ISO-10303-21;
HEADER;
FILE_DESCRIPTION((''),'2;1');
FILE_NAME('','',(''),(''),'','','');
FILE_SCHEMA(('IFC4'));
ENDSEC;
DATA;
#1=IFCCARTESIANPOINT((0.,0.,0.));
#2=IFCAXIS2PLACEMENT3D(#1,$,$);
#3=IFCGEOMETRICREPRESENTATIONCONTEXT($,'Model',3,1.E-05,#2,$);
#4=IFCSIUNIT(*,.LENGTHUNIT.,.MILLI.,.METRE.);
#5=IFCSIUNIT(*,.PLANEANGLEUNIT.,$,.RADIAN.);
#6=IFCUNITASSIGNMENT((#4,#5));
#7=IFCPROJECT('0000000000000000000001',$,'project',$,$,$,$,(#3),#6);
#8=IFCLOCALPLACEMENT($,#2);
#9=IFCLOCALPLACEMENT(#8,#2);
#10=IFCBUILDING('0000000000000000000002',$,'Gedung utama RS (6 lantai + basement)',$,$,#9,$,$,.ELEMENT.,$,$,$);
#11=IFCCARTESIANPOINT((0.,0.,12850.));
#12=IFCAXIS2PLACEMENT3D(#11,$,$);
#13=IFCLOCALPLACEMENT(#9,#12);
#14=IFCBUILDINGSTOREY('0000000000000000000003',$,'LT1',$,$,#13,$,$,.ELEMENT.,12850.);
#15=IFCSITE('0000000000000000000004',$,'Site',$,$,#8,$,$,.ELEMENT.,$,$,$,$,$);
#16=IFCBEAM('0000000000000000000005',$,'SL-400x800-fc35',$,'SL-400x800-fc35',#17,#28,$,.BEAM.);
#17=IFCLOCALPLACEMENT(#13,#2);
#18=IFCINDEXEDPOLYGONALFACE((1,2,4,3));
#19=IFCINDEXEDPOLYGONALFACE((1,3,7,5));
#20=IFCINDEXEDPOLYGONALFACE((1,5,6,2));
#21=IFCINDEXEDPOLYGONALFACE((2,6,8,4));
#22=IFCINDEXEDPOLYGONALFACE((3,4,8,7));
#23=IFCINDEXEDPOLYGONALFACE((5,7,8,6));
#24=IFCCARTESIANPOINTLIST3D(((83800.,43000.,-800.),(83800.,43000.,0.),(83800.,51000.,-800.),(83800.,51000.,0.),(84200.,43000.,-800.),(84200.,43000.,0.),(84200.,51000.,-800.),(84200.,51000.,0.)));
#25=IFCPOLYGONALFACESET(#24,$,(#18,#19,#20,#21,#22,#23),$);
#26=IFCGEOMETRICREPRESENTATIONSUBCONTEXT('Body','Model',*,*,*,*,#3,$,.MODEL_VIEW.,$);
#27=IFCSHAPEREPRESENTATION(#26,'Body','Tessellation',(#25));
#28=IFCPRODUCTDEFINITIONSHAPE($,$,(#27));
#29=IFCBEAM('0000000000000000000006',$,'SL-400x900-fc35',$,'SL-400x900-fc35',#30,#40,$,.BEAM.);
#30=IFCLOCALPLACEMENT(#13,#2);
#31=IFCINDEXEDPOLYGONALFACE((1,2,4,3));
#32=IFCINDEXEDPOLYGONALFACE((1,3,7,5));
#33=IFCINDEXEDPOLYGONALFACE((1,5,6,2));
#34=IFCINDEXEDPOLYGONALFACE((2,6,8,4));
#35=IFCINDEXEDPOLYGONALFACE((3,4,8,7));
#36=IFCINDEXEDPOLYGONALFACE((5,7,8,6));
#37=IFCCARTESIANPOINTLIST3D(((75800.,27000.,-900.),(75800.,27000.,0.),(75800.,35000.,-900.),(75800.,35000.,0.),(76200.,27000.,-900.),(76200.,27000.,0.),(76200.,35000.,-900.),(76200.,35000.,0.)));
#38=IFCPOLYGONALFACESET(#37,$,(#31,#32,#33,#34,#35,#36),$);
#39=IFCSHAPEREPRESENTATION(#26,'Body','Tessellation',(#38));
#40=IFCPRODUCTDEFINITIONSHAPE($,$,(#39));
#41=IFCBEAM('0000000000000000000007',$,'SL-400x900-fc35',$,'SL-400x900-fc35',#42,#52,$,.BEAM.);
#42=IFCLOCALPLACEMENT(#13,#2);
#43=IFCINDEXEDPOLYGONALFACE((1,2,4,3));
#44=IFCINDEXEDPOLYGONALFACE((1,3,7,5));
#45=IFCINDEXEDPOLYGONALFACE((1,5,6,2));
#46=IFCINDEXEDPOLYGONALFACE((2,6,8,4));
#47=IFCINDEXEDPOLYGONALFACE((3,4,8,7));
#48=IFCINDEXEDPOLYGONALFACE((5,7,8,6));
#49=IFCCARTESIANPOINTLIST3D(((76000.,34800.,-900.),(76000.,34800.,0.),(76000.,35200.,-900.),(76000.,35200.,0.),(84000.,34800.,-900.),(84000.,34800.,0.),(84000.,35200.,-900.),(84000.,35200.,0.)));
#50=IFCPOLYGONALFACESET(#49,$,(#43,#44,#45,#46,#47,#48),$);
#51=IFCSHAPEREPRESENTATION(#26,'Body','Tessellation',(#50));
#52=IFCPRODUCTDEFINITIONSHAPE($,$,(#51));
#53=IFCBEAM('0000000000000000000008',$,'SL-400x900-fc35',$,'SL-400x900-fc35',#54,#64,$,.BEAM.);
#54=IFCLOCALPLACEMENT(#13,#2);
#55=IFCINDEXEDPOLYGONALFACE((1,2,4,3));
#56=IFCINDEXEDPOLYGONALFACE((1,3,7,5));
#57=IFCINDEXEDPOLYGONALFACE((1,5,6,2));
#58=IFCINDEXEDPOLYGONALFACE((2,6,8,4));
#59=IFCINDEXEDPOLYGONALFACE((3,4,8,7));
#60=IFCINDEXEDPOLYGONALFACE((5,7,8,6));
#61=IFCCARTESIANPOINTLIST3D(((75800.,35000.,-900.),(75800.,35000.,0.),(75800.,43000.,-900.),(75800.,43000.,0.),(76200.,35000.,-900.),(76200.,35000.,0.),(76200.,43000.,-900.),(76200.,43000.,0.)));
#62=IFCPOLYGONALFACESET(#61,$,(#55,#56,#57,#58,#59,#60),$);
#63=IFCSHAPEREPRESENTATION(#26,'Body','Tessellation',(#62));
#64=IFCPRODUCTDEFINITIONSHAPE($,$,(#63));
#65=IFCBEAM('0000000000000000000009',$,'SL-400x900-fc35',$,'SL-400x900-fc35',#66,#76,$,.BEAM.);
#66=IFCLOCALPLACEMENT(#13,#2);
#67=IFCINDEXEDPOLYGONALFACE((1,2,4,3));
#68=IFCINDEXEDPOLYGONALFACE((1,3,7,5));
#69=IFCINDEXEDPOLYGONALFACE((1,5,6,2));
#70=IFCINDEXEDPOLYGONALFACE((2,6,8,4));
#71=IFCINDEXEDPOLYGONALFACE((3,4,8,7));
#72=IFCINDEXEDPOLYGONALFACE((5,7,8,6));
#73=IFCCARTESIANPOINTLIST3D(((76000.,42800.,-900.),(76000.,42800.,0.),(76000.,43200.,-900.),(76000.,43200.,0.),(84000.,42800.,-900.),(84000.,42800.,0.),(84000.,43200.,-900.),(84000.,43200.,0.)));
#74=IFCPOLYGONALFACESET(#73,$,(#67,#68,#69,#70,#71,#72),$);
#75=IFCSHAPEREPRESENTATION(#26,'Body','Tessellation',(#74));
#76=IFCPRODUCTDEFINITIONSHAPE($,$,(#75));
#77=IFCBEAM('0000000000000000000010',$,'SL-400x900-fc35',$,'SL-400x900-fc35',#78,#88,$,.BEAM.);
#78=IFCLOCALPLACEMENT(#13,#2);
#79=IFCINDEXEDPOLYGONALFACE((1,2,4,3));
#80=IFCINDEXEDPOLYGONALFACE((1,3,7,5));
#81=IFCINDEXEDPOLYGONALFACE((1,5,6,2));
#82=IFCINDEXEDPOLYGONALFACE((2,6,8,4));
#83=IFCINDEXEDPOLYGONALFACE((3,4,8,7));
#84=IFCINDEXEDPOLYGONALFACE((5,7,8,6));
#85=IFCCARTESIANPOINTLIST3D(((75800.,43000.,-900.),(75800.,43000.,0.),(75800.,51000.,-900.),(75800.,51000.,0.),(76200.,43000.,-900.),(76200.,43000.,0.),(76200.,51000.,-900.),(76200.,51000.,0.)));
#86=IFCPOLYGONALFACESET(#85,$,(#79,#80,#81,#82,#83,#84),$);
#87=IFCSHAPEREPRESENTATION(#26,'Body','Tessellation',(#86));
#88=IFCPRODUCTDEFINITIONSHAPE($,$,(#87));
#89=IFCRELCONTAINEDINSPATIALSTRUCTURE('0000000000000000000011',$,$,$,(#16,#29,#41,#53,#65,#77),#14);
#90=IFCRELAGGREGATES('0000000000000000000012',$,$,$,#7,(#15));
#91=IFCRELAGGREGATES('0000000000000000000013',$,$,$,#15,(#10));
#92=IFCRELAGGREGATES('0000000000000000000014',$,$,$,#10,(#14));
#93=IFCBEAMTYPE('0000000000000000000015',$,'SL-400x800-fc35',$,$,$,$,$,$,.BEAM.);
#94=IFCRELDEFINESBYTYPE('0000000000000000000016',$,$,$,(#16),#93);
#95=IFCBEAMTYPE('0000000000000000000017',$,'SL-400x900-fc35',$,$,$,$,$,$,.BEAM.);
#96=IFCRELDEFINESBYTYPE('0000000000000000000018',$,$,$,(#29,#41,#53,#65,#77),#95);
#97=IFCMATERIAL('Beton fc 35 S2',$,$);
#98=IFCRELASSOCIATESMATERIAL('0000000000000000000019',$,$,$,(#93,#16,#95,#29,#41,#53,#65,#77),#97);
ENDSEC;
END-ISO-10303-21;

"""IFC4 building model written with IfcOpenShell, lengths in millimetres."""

from ifc_helpers import new_model, si_unit, frame, origin, origin_2d, place, context, subcontext, project, spatial, rectangle, extrude, material, material_profile, profile_set, profile_usage, type_object, element, save


model = new_model("IFC4")

# Units and contexts
model_context = context("Model", 3, precision=1e-05, world=origin())
body_context = subcontext(model_context, "Body", "Model", "MODEL_VIEW")
ifc_project = project(units=[si_unit("LENGTHUNIT", "METRE", prefix="MILLI"), si_unit("PLANEANGLEUNIT", "RADIAN")], contexts=[model_context])

# Site, building, storey
site_placement = place(None, origin())
site = spatial("IfcSite", under=ifc_project, at=site_placement, Name="Site", CompositionType="ELEMENT")
building_placement = place(site_placement, origin())
building = spatial("IfcBuilding", under=site, at=building_placement, Name="Gedung utama RS (6 lantai + basement)", CompositionType="ELEMENT")
storey_placement = place(building_placement, frame((0.0, 0.0, 12850.0)))
storey = spatial("IfcBuildingStorey", under=building, at=storey_placement, Name="LT1", CompositionType="ELEMENT", Elevation=12850.0)

# Beams
ifc_material = material(Name="Beton fc 35 S2")
ifc_material_profile_1 = material_profile(ifc_material, rectangle(XDim=400.0, YDim=800.0, at=origin_2d()), Name="SL-400x800-fc35")
ifc_profile_set_1 = profile_set([ifc_material_profile_1], Name="SL-400x800-fc35")
ifc_profile_usage_1 = profile_usage(ifc_profile_set_1, cardinal=8)
beam_type_1 = type_object("IfcBeamType", Name="SL-400x800-fc35", PredefinedType="BEAM", material=ifc_profile_set_1)
for number, where, name in (
    (1, (84000.0, 43000.0, -400.0), "SL-400x800-fc35"),
):
    element("IfcBeam", number, at=place(storey_placement, frame(where)), inside=storey, type_object=beam_type_1, material=ifc_profile_usage_1, Name=name, ObjectType="SL-400x800-fc35", PredefinedType="BEAM", context=body_context, shape_type="SweptSolid", body=[
        extrude(rectangle(XDim=400.0, YDim=800.0, at=origin_2d()), frame((0.0, 0.0, 0.0), z_axis=(0.0, 1.0, 0.0), x_axis=(-1.0, 0.0, 0.0)), (0.0, 0.0, 1.0), 8000.0),
    ])
ifc_material_profile_2 = material_profile(ifc_material, rectangle(XDim=400.0, YDim=900.0, at=origin_2d()), Name="SL-400x900-fc35")
ifc_profile_set_2 = profile_set([ifc_material_profile_2], Name="SL-400x900-fc35")
ifc_profile_usage_2 = profile_usage(ifc_profile_set_2, cardinal=8)
beam_type_2 = type_object("IfcBeamType", Name="SL-400x900-fc35", PredefinedType="BEAM", material=ifc_profile_set_2)
beam_1_placement = place(storey_placement, frame((76000.0, 27000.0, -450.0)))
element("IfcBeam", 2, at=beam_1_placement, inside=storey, type_object=beam_type_2, material=ifc_profile_usage_2, Name="SL-400x900-fc35", ObjectType="SL-400x900-fc35", PredefinedType="BEAM", context=body_context, shape_type="SweptSolid", body=[
    extrude(rectangle(XDim=400.0, YDim=900.0, at=origin_2d()), frame((0.0, 0.0, 0.0), z_axis=(0.0, 1.0, 0.0), x_axis=(-1.0, 0.0, 0.0)), (0.0, 0.0, 1.0), 8000.0),
])
beam_2_placement = place(storey_placement, frame((76000.0, 35000.0, -450.0)))
element("IfcBeam", 3, at=beam_2_placement, inside=storey, type_object=beam_type_2, material=ifc_profile_usage_2, Name="SL-400x900-fc35", ObjectType="SL-400x900-fc35", PredefinedType="BEAM", context=body_context, shape_type="SweptSolid", body=[
    extrude(rectangle(XDim=400.0, YDim=900.0, at=origin_2d()), frame((0.0, 0.0, 0.0), z_axis=(1.0, 0.0, 0.0), x_axis=(0.0, 1.0, 0.0)), (0.0, 0.0, 1.0), 8000.0),
])
beam_3_placement = place(storey_placement, frame((76000.0, 35000.0, -450.0)))
element("IfcBeam", 4, at=beam_3_placement, inside=storey, type_object=beam_type_2, material=ifc_profile_usage_2, Name="SL-400x900-fc35", ObjectType="SL-400x900-fc35", PredefinedType="BEAM", context=body_context, shape_type="SweptSolid", body=[
    extrude(rectangle(XDim=400.0, YDim=900.0, at=origin_2d()), frame((0.0, 0.0, 0.0), z_axis=(0.0, 1.0, 0.0), x_axis=(-1.0, 0.0, 0.0)), (0.0, 0.0, 1.0), 8000.0),
])
beam_4_placement = place(storey_placement, frame((76000.0, 43000.0, -450.0)))
element("IfcBeam", 5, at=beam_4_placement, inside=storey, type_object=beam_type_2, material=ifc_profile_usage_2, Name="SL-400x900-fc35", ObjectType="SL-400x900-fc35", PredefinedType="BEAM", context=body_context, shape_type="SweptSolid", body=[
    extrude(rectangle(XDim=400.0, YDim=900.0, at=origin_2d()), frame((0.0, 0.0, 0.0), z_axis=(1.0, 0.0, 0.0), x_axis=(0.0, 1.0, 0.0)), (0.0, 0.0, 1.0), 8000.0),
])
beam_5_placement = place(storey_placement, frame((76000.0, 43000.0, -450.0)))
element("IfcBeam", 6, at=beam_5_placement, inside=storey, type_object=beam_type_2, material=ifc_profile_usage_2, Name="SL-400x900-fc35", ObjectType="SL-400x900-fc35", PredefinedType="BEAM", context=body_context, shape_type="SweptSolid", body=[
    extrude(rectangle(XDim=400.0, YDim=900.0, at=origin_2d()), frame((0.0, 0.0, 0.0), z_axis=(0.0, 1.0, 0.0), x_axis=(-1.0, 0.0, 0.0)), (0.0, 0.0, 1.0), 8000.0),
])

save(model, "model.ifc")
